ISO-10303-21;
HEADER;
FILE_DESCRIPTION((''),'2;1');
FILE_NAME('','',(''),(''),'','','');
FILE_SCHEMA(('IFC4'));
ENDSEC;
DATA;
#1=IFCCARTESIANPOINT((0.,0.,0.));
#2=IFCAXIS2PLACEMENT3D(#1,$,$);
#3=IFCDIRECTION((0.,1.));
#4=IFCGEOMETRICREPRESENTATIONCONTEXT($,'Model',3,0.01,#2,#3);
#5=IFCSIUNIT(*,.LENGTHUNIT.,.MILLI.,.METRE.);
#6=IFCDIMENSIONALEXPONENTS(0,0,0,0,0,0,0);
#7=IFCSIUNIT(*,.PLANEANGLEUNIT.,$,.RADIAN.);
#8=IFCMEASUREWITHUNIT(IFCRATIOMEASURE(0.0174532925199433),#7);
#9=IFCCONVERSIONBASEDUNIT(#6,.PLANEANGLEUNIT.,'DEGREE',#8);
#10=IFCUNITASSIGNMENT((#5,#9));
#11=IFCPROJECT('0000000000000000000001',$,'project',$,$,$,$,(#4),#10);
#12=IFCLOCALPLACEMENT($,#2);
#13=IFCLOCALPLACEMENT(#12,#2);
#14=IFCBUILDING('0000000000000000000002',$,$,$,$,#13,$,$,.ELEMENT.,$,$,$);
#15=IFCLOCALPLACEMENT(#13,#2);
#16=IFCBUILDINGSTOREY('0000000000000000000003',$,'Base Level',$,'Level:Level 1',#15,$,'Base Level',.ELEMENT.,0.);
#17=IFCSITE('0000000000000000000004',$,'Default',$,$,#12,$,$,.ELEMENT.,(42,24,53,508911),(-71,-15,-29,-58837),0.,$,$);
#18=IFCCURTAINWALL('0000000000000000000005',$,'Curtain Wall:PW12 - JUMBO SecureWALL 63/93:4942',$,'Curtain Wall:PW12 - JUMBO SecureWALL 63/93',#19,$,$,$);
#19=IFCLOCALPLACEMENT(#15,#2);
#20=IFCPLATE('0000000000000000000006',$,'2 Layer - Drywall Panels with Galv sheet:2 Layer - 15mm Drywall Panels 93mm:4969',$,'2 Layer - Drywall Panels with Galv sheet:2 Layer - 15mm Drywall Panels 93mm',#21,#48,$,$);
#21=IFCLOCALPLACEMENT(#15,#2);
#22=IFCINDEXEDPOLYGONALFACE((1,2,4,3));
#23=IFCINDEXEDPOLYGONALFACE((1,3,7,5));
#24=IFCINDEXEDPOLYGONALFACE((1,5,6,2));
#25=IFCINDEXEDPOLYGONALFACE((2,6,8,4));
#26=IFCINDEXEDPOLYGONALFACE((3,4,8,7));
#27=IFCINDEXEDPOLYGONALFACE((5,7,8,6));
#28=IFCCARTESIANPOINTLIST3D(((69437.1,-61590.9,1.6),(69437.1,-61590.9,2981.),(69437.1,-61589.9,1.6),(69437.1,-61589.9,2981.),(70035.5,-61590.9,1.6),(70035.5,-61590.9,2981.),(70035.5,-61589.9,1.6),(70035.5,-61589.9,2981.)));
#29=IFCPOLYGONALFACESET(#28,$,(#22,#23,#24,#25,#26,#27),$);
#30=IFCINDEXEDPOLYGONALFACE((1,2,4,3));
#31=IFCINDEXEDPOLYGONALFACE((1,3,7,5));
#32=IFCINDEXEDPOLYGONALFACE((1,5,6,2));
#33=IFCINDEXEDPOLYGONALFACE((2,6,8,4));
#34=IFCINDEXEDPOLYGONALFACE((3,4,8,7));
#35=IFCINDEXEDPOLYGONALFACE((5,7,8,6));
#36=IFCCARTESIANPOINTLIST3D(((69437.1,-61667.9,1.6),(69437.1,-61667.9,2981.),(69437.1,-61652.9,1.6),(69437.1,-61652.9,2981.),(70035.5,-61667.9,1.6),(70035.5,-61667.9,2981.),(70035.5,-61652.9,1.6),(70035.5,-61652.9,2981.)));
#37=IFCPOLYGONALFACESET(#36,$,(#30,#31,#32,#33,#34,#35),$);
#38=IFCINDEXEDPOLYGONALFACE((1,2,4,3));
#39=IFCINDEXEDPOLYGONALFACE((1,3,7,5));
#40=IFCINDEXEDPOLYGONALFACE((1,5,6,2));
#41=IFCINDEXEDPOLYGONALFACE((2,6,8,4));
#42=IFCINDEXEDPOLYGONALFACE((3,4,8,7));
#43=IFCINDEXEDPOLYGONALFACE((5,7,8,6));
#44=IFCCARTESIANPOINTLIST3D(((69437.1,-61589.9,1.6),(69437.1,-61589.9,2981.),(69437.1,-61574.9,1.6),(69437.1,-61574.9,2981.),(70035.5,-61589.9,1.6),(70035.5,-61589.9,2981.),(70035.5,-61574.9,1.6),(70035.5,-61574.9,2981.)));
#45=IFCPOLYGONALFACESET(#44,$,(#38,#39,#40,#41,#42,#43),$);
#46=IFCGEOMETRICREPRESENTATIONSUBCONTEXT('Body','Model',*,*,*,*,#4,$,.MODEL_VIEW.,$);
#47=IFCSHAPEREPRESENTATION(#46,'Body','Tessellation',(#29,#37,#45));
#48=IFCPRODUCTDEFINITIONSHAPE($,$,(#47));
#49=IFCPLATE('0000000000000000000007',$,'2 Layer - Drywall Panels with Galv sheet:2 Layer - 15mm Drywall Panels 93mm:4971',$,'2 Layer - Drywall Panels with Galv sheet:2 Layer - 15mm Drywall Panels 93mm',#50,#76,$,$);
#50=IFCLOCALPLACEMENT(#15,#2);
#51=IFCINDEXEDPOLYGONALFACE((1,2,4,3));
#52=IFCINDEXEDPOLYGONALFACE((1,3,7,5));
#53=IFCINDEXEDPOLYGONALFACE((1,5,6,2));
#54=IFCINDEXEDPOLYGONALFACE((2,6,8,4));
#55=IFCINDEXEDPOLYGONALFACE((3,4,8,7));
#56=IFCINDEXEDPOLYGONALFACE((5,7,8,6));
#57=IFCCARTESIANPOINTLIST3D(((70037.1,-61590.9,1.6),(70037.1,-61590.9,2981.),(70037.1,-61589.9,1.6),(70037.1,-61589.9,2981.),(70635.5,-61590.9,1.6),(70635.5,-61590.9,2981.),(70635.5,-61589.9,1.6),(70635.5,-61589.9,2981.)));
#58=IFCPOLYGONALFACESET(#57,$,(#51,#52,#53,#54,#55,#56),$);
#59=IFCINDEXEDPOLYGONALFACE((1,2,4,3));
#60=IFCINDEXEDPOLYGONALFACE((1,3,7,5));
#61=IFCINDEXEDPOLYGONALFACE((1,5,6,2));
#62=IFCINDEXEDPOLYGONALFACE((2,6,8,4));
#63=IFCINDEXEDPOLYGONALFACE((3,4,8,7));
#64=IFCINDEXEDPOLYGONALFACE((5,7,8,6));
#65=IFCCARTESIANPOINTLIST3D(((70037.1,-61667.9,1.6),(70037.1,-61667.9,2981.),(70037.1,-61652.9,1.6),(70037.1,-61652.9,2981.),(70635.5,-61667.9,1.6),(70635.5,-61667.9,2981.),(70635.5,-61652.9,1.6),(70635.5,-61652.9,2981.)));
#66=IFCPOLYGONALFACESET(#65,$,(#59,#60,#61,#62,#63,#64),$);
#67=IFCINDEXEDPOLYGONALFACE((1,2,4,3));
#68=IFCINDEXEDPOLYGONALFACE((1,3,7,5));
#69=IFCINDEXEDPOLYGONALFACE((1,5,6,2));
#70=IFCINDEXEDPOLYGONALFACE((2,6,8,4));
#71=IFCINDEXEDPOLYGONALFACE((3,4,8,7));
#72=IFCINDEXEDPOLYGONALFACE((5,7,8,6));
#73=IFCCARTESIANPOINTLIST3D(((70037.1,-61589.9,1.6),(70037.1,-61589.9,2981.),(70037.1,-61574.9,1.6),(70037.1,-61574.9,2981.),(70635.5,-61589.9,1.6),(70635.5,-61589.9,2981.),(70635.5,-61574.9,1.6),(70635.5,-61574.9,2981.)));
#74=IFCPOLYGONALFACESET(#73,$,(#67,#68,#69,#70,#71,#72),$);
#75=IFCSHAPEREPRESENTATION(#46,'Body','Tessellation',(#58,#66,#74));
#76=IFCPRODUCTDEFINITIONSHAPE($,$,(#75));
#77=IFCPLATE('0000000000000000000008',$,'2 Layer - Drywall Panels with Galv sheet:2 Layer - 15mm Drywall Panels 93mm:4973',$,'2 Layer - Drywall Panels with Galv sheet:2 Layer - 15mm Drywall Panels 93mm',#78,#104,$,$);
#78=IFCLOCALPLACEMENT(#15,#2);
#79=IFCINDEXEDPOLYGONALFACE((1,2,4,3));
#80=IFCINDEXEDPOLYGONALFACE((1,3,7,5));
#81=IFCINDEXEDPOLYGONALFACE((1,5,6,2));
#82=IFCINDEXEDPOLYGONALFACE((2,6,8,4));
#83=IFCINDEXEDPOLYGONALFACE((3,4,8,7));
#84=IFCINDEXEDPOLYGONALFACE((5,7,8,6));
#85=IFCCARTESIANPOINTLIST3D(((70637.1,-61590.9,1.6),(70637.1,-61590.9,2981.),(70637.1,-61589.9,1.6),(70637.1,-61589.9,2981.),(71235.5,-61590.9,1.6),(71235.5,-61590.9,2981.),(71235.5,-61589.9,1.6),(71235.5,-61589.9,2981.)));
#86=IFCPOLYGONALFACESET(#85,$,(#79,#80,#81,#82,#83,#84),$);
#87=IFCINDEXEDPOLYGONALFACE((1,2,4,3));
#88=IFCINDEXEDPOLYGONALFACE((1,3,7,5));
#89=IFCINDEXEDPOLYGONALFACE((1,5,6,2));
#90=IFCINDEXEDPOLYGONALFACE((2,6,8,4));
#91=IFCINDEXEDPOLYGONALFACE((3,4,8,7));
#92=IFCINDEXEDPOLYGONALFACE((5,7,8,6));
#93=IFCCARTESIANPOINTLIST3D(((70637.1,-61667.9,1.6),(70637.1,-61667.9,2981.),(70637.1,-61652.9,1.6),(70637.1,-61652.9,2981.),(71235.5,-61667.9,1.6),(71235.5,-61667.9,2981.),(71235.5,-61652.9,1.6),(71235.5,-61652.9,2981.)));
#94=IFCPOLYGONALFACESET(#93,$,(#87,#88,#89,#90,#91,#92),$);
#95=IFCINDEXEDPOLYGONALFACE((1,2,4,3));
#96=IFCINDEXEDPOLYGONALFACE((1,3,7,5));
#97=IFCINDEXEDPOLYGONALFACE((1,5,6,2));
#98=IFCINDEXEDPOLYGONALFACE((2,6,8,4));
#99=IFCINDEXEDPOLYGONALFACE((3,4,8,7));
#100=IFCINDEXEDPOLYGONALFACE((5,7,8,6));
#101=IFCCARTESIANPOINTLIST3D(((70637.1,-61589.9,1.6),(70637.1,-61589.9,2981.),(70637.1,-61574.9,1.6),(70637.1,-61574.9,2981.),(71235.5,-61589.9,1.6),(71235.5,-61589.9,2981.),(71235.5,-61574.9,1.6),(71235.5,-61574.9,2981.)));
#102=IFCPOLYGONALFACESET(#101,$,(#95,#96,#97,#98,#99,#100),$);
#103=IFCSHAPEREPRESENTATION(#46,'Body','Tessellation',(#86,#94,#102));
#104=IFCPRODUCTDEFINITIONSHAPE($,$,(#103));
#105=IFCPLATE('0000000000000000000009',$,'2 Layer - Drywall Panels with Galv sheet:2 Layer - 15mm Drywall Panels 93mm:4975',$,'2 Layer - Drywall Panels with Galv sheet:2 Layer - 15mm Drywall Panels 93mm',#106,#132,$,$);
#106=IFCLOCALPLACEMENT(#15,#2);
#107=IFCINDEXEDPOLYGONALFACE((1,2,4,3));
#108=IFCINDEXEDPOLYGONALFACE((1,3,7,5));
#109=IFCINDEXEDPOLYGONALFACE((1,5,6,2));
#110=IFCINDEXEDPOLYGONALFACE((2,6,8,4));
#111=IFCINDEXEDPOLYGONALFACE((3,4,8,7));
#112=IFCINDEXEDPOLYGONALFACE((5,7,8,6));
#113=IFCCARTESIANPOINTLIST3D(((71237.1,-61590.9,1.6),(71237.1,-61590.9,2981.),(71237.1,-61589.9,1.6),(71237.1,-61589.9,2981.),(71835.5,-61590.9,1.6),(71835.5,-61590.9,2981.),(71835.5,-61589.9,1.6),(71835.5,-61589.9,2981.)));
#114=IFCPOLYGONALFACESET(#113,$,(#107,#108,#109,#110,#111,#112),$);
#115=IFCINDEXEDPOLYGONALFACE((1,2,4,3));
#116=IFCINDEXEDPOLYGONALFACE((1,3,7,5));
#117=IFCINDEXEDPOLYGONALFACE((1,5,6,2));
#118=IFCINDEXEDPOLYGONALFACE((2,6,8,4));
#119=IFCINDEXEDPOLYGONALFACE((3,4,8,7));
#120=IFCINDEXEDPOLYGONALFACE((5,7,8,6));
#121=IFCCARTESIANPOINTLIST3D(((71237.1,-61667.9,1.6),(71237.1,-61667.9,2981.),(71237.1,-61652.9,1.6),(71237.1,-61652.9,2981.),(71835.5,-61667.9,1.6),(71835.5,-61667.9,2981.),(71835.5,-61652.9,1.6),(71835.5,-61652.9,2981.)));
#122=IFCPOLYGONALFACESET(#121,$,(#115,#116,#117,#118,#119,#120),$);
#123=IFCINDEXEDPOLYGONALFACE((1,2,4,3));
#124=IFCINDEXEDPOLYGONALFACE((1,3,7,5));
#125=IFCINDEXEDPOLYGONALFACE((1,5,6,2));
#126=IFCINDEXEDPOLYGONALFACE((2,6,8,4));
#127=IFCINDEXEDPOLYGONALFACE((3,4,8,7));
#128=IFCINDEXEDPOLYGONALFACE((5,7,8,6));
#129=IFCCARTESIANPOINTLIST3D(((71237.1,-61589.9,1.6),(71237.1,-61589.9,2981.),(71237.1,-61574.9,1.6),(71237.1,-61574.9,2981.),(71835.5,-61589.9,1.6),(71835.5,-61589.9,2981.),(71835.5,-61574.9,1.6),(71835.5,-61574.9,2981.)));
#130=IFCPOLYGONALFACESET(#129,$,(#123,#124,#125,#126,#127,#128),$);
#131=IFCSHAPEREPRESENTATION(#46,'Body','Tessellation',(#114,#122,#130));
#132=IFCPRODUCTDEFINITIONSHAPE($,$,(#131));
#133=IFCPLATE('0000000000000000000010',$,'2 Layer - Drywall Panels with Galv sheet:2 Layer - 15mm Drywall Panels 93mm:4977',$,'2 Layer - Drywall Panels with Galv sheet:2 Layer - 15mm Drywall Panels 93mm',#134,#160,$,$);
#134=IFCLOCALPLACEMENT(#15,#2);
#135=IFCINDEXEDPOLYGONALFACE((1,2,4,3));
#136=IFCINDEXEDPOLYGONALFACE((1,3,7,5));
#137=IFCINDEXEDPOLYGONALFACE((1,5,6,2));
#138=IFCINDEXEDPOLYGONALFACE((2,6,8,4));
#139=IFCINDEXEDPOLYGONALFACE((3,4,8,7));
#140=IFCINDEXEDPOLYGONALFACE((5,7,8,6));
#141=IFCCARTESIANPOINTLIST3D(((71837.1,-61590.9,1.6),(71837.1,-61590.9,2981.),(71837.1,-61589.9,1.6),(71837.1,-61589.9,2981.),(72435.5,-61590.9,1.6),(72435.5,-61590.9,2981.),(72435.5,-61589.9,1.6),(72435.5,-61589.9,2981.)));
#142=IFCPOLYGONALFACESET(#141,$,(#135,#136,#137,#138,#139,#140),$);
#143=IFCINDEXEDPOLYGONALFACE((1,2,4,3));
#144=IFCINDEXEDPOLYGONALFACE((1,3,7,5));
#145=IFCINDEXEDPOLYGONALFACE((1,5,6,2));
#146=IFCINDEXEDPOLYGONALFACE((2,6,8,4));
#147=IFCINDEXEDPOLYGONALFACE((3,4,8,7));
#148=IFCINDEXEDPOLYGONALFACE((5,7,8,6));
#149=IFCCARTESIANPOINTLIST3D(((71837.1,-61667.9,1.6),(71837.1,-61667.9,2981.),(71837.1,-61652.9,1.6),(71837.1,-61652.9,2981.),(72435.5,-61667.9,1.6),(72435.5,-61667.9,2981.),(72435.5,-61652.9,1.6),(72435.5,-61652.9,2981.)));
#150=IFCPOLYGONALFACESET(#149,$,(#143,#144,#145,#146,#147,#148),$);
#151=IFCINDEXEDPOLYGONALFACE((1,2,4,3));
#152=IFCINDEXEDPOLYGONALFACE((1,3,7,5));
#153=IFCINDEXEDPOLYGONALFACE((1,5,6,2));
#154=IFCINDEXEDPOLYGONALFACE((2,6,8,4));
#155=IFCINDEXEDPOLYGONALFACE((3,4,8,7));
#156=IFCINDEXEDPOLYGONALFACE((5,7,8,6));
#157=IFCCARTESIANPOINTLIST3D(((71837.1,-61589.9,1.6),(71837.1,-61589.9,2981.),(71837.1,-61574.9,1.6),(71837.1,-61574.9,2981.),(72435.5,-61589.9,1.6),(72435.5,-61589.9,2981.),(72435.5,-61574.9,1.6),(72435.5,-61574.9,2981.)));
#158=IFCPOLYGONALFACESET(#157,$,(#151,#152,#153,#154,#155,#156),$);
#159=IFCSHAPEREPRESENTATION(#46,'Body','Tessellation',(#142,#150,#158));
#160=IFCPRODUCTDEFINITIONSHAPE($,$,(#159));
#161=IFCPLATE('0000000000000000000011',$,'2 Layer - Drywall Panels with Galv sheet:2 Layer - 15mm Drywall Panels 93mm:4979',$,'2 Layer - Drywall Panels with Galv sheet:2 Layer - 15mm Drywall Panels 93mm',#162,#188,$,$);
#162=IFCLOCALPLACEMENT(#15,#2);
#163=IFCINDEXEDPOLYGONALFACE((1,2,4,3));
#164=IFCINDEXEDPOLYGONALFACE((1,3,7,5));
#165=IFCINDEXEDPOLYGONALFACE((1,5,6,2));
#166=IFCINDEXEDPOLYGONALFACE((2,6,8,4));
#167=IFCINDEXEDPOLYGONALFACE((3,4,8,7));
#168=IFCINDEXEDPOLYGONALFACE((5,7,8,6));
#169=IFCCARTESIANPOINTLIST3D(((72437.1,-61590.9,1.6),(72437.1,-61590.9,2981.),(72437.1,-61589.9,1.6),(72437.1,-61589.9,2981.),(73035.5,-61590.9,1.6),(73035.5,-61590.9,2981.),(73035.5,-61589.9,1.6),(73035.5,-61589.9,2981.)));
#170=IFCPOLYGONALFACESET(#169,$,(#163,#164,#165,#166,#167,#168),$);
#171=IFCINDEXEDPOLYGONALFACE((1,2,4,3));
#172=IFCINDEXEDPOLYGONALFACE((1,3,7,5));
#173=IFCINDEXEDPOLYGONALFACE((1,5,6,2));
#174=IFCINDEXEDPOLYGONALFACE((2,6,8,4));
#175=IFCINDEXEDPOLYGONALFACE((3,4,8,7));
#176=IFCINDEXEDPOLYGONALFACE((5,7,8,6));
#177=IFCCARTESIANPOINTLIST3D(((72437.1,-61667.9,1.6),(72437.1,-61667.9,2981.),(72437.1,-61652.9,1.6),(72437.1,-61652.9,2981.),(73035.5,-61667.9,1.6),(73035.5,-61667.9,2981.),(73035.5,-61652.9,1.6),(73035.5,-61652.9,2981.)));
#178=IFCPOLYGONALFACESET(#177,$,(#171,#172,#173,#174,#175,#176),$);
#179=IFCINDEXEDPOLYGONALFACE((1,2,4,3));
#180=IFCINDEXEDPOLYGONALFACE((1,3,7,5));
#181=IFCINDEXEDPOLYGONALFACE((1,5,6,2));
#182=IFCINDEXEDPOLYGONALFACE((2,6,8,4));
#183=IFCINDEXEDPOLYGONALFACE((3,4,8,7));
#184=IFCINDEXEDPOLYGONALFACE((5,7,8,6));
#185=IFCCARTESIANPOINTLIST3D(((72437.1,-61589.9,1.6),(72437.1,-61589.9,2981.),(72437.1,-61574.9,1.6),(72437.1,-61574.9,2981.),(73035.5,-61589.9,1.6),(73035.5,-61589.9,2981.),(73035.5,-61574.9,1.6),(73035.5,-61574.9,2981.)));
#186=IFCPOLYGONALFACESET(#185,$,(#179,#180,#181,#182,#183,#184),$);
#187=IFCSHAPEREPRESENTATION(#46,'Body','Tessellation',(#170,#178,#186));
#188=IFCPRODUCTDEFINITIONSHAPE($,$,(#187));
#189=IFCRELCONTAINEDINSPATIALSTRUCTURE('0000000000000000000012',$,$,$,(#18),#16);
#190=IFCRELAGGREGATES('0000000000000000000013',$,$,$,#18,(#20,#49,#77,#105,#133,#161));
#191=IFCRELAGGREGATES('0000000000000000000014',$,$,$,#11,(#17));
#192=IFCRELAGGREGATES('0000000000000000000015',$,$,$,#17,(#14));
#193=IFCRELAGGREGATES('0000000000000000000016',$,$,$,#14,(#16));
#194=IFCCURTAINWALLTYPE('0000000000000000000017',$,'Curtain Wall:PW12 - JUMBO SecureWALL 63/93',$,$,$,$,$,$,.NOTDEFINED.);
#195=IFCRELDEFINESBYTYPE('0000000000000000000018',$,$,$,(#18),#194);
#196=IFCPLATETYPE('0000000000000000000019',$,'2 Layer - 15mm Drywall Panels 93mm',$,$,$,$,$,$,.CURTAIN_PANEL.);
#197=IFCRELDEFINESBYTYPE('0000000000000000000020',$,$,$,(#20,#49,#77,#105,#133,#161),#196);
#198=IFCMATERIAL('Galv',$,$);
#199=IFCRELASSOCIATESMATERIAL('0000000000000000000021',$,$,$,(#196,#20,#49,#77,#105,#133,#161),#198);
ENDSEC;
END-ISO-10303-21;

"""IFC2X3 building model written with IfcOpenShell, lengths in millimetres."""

from ifc_helpers import new_model, entity, si_unit, converted_unit, direction, frame, frame_2d, origin, origin_2d_with_axis, place, context, subcontext, project, spatial, rectangle, extrude, source, transform, mapped, material, type_object, type_shapes, element, aggregate, save


model = new_model("IFC2X3")

# Units and contexts
model_context = context("Model", 3, precision=0.01, world=origin(), true_north=direction((0.0, 1.0)))
body_context = subcontext(model_context, "Body", "Model", "MODEL_VIEW")
ifc_project = project(units=[si_unit("LENGTHUNIT", "METRE", prefix="MILLI"), converted_unit("PLANEANGLEUNIT", "DEGREE", entity("IfcRatioMeasure", 0.0174532925199433), si_unit("PLANEANGLEUNIT", "RADIAN"), dimensions=[0, 0, 0, 0, 0, 0, 0])], contexts=[model_context])

# Site, building, storey
site_placement = place(None, origin())
site = spatial("IfcSite", under=ifc_project, at=site_placement, Name="Default", CompositionType="ELEMENT", RefLatitude=(42, 24, 53, 508911), RefLongitude=(-71, -15, -29, -58837), RefElevation=0.0)
building_placement = place(site_placement, origin())
building = spatial("IfcBuilding", under=site, at=building_placement, CompositionType="ELEMENT")
storey_placement = place(building_placement, origin())
storey = spatial("IfcBuildingStorey", under=building, at=storey_placement, Name="Base Level", ObjectType="Level:Level 1", LongName="Base Level", CompositionType="ELEMENT", Elevation=0.0)

# Curtain wall, plates
curtain_wall_type = type_object("IfcCurtainWallType", Name="Curtain Wall:PW12 - JUMBO SecureWALL 63/93", PredefinedType="NOTDEFINED")
curtain_wall_placement = place(building_placement, origin())
curtain_wall = element("IfcCurtainWall", 1, at=curtain_wall_placement, inside=storey, type_object=curtain_wall_type, Name="Curtain Wall:PW12 - JUMBO SecureWALL 63/93:4942", ObjectType="Curtain Wall:PW12 - JUMBO SecureWALL 63/93")
ifc_material_1 = material(Name="Galv")
plate_type = type_object("IfcPlateType", Name="2 Layer - 15mm Drywall Panels 93mm", PredefinedType="CURTAIN_PANEL", material=ifc_material_1)
shared_shape_1 = source(origin(), body_context, "Body", "SweptSolid", [
    extrude(rectangle(XDim=598.4, YDim=1.0, at=origin_2d_with_axis()), frame((0.0, 31.0, 0.0), z_axis=(0.0, 0.0, 1.0), x_axis=(-1.0, 0.0, 0.0)), (0.0, 0.0, 1.0), 2979.4),
    extrude(rectangle(XDim=598.4, YDim=15.0, at=frame_2d((0.0, 0.0), x_axis=(1.0, 0.0))), frame((0.0, -39.0, 0.0), z_axis=(0.0, 0.0, 1.0), x_axis=(-1.0, 0.0, 0.0)), (0.0, 0.0, 1.0), 2979.4),
    extrude(rectangle(XDim=15.0, YDim=598.4, at=frame_2d((0.0, 0.0), x_axis=(1.0, 0.0))), frame((0.0, 39.0, 0.0), z_axis=(0.0, 0.0, 1.0), x_axis=(0.0, 1.0, 0.0)), (0.0, 0.0, 1.0), 2979.4),
])
type_shapes(plate_type, [shared_shape_1])
plate_1_placement = place(curtain_wall_placement, frame((69736.3, -61621.4, 1.6)))
plate_1 = element("IfcPlate", 2, at=plate_1_placement, type_object=plate_type, material=ifc_material_1, Name="2 Layer - Drywall Panels with Galv sheet:2 Layer - 15mm Drywall Panels 93mm:4969", ObjectType="2 Layer - Drywall Panels with Galv sheet:2 Layer - 15mm Drywall Panels 93mm", context=body_context, shape_type="MappedRepresentation", body=[
    mapped(shared_shape_1, transform((0.0, 0.0, 0.0), scale=1.0)),
])
plate_2_placement = place(curtain_wall_placement, frame((70336.3, -61621.4, 1.6)))
plate_2 = element("IfcPlate", 3, at=plate_2_placement, type_object=plate_type, material=ifc_material_1, Name="2 Layer - Drywall Panels with Galv sheet:2 Layer - 15mm Drywall Panels 93mm:4971", ObjectType="2 Layer - Drywall Panels with Galv sheet:2 Layer - 15mm Drywall Panels 93mm", context=body_context, shape_type="MappedRepresentation", body=[
    mapped(shared_shape_1, transform((0.0, 0.0, 0.0), scale=1.0)),
])
plate_3_placement = place(curtain_wall_placement, frame((70936.3, -61621.4, 1.6)))
plate_3 = element("IfcPlate", 4, at=plate_3_placement, type_object=plate_type, material=ifc_material_1, Name="2 Layer - Drywall Panels with Galv sheet:2 Layer - 15mm Drywall Panels 93mm:4973", ObjectType="2 Layer - Drywall Panels with Galv sheet:2 Layer - 15mm Drywall Panels 93mm", context=body_context, shape_type="MappedRepresentation", body=[
    mapped(shared_shape_1, transform((0.0, 0.0, 0.0), scale=1.0)),
])
plate_4_placement = place(curtain_wall_placement, frame((71536.3, -61621.4, 1.6)))
plate_4 = element("IfcPlate", 5, at=plate_4_placement, type_object=plate_type, material=ifc_material_1, Name="2 Layer - Drywall Panels with Galv sheet:2 Layer - 15mm Drywall Panels 93mm:4975", ObjectType="2 Layer - Drywall Panels with Galv sheet:2 Layer - 15mm Drywall Panels 93mm", context=body_context, shape_type="MappedRepresentation", body=[
    mapped(shared_shape_1, transform((0.0, 0.0, 0.0), scale=1.0)),
])
plate_5_placement = place(curtain_wall_placement, frame((72136.3, -61621.4, 1.6)))
plate_5 = element("IfcPlate", 6, at=plate_5_placement, type_object=plate_type, material=ifc_material_1, Name="2 Layer - Drywall Panels with Galv sheet:2 Layer - 15mm Drywall Panels 93mm:4977", ObjectType="2 Layer - Drywall Panels with Galv sheet:2 Layer - 15mm Drywall Panels 93mm", context=body_context, shape_type="MappedRepresentation", body=[
    mapped(shared_shape_1, transform((0.0, 0.0, 0.0), scale=1.0)),
])
plate_6_placement = place(curtain_wall_placement, frame((72736.3, -61621.4, 1.6)))
plate_6 = element("IfcPlate", 7, at=plate_6_placement, type_object=plate_type, material=ifc_material_1, Name="2 Layer - Drywall Panels with Galv sheet:2 Layer - 15mm Drywall Panels 93mm:4979", ObjectType="2 Layer - Drywall Panels with Galv sheet:2 Layer - 15mm Drywall Panels 93mm", context=body_context, shape_type="MappedRepresentation", body=[
    mapped(shared_shape_1, transform((0.0, 0.0, 0.0), scale=1.0)),
])
aggregate(curtain_wall, [plate_1, plate_2, plate_3, plate_4, plate_5, plate_6])

save(model, "model.ifc")
